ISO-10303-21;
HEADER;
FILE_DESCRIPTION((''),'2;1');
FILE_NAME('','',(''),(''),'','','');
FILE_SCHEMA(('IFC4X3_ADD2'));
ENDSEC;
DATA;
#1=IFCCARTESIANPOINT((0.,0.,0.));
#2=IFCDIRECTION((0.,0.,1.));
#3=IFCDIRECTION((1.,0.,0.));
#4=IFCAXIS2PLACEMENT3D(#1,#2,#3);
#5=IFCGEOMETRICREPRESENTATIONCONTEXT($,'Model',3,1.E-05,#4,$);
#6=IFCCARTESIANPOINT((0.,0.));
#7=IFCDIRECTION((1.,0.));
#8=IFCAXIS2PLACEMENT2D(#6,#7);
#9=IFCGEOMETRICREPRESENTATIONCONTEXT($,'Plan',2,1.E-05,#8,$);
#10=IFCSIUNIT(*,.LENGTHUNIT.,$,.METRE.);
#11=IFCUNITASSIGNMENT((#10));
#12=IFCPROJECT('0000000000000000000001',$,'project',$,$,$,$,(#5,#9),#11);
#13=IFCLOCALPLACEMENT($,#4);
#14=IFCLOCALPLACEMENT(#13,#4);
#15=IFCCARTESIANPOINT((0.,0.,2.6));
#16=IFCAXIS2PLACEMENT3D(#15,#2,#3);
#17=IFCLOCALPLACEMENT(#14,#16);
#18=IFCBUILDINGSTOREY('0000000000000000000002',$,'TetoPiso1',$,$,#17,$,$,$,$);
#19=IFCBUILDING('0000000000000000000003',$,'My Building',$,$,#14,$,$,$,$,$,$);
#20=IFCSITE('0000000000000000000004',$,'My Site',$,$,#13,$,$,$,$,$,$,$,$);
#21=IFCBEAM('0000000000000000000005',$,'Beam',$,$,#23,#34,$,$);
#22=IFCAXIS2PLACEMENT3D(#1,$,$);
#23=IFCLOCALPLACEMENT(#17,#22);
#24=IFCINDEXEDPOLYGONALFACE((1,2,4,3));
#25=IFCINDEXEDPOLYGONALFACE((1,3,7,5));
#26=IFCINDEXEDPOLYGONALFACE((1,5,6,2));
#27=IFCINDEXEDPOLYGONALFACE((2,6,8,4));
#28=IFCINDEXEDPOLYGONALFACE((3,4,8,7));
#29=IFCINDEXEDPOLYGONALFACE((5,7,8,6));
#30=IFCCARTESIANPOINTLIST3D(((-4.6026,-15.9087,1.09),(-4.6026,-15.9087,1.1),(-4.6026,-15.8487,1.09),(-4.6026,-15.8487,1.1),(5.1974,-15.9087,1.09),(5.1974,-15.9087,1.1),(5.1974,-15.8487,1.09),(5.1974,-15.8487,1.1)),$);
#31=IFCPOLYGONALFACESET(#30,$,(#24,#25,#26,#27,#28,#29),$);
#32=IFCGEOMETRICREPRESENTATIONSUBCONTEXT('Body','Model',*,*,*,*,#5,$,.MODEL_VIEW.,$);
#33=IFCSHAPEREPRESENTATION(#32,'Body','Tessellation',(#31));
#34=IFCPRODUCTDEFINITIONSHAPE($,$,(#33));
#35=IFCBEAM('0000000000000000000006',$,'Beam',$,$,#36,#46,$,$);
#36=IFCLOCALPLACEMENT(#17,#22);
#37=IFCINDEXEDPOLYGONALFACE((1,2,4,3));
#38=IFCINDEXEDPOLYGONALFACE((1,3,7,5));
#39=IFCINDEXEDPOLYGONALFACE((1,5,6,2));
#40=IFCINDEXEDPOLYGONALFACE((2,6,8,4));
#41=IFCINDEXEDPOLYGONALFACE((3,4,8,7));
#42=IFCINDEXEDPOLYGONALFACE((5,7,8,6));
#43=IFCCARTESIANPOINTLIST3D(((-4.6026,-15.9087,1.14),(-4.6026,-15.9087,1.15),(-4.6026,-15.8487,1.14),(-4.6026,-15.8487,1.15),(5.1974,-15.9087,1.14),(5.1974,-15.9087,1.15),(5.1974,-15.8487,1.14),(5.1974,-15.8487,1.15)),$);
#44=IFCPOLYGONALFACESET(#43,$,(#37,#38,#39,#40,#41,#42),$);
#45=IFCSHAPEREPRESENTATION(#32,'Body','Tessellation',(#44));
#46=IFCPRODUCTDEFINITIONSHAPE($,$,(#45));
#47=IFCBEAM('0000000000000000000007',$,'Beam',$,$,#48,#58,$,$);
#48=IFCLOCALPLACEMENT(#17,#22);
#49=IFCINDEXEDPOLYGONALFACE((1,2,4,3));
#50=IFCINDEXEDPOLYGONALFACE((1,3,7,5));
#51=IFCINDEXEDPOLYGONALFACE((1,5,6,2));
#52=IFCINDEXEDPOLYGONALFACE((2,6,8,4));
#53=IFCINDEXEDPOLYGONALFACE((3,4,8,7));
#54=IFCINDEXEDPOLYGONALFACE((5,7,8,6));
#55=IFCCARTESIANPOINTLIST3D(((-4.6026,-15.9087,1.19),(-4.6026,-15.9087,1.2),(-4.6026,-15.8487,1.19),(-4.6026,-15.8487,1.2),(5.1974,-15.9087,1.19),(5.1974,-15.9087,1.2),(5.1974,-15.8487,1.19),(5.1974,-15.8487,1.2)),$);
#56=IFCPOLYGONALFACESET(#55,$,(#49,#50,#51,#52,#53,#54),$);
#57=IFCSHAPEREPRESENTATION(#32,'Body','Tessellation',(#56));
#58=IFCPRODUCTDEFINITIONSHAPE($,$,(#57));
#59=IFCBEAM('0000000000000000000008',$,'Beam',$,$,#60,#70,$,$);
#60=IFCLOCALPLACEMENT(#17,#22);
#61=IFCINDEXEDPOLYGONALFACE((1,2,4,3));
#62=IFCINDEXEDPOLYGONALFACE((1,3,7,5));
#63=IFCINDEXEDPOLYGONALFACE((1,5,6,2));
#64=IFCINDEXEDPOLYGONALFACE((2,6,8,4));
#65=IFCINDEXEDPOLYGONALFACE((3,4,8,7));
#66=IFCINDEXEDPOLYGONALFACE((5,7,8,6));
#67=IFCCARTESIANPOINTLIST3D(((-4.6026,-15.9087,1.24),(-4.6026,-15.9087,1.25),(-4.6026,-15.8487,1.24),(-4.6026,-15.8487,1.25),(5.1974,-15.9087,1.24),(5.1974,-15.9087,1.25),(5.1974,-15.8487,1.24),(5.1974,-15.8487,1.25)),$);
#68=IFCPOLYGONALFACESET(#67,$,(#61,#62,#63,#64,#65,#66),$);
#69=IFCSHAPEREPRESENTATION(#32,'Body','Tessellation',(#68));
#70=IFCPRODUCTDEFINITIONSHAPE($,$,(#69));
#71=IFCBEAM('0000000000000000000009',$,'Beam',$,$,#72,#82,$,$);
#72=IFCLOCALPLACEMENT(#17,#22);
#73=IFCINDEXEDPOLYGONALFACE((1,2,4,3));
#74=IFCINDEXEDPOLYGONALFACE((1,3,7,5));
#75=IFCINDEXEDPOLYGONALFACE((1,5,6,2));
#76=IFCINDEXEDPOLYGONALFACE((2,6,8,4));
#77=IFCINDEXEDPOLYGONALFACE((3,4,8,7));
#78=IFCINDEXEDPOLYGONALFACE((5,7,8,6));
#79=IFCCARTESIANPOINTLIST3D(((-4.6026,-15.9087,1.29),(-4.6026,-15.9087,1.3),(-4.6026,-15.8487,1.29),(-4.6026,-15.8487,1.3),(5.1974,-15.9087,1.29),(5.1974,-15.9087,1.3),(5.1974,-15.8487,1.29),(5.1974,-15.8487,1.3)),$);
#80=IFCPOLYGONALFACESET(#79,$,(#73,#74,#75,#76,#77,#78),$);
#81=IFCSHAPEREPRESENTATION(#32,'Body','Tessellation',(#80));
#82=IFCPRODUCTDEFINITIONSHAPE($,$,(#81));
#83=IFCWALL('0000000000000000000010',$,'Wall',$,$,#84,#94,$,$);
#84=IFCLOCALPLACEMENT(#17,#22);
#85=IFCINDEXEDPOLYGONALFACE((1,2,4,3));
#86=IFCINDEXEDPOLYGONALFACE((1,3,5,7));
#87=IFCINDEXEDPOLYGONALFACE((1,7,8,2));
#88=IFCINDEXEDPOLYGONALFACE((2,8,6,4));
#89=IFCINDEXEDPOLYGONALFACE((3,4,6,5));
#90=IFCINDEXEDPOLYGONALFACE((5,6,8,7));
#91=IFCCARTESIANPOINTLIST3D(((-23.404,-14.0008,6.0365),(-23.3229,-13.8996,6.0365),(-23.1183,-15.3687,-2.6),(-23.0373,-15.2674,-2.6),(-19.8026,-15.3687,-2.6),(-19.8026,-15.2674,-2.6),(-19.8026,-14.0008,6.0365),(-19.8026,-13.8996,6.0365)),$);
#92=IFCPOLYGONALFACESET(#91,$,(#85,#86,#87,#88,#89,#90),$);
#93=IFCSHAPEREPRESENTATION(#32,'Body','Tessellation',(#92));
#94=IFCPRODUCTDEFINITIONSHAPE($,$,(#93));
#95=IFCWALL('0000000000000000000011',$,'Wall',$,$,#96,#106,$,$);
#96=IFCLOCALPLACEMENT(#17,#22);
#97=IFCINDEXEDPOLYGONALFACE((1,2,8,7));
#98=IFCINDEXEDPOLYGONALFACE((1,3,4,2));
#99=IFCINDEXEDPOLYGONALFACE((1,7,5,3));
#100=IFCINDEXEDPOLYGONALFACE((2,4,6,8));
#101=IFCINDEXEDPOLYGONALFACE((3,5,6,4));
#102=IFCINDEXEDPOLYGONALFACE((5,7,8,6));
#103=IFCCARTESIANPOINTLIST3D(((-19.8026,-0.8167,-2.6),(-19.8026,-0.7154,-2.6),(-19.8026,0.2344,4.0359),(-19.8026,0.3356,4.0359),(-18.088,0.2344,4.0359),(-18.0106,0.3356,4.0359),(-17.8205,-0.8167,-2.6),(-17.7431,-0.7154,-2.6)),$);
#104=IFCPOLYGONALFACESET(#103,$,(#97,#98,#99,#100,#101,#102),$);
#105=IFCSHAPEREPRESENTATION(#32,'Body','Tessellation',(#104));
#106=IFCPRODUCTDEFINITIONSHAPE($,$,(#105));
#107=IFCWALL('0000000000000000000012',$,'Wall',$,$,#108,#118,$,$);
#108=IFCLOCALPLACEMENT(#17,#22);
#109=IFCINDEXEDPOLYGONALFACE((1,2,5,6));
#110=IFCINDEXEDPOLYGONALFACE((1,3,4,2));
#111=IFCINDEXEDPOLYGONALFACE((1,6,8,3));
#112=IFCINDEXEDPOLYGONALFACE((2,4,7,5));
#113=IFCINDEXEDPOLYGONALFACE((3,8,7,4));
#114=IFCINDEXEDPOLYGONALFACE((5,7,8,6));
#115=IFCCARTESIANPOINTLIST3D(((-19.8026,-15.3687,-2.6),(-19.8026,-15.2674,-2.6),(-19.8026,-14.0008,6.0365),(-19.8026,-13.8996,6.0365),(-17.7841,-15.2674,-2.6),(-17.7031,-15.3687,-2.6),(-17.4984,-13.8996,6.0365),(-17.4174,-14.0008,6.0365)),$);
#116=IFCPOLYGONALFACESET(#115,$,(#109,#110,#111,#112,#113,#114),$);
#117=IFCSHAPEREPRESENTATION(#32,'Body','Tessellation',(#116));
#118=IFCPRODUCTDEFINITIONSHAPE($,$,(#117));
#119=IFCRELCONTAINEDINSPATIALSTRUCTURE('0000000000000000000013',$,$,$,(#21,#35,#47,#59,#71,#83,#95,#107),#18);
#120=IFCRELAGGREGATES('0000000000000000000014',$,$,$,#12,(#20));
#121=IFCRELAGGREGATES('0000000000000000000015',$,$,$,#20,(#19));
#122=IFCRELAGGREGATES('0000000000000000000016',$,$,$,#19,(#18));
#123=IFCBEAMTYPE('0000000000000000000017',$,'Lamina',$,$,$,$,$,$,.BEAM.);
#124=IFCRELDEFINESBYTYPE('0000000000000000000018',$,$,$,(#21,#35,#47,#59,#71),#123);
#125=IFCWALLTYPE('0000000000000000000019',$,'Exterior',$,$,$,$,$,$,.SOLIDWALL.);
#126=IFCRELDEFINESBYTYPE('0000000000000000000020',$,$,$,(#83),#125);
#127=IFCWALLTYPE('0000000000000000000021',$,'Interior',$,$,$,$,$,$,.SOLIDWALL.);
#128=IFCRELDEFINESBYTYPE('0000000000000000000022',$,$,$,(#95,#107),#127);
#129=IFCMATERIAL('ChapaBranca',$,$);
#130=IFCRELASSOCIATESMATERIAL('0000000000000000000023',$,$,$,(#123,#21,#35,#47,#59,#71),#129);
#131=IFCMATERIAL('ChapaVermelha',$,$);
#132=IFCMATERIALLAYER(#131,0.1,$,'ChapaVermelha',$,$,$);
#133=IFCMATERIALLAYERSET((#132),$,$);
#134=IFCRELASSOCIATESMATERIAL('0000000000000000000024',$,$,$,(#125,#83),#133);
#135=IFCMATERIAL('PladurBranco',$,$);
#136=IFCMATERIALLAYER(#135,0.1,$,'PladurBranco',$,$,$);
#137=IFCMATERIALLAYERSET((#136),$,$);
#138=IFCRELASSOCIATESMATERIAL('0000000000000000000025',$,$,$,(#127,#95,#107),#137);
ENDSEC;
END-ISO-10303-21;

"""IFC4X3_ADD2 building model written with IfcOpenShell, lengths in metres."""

from ifc_helpers import new_model, si_unit, frame, origin_with_axes, origin_2d, origin_2d_with_axis, place, context, subcontext, project, spatial, line, indexed_curve, rectangle, outline, extrude, boolean, material, layer, layer_set, layer_usage, material_profile, profile_set, profile_usage, type_object, element, save


model = new_model("IFC4X3_ADD2")

# Units and contexts
model_context = context("Model", 3, precision=1e-05, world=origin_with_axes())
plan_context = context("Plan", 2, precision=1e-05, world=origin_2d_with_axis())
body_context = subcontext(model_context, "Body", "Model", "MODEL_VIEW")
ifc_project = project(units=[si_unit("LENGTHUNIT", "METRE")], contexts=[model_context, plan_context])

# Site, building, storey
site_placement = place(None, origin_with_axes())
site = spatial("IfcSite", under=ifc_project, at=site_placement, Name="My Site")
building_placement = place(site_placement, origin_with_axes())
building = spatial("IfcBuilding", under=site, at=building_placement, Name="My Building")
storey_placement = place(building_placement, frame((0.0, 0.0, 2.6), z_axis=(0.0, 0.0, 1.0), x_axis=(1.0, 0.0, 0.0)))
storey = spatial("IfcBuildingStorey", under=building, at=storey_placement, Name="TetoPiso1")

# Beams
ifc_material_1 = material(Name="ChapaBranca")
ifc_material_profile_1 = material_profile(ifc_material_1, rectangle(XDim=0.06, YDim=0.01, at=origin_2d()))
ifc_profile_set_1 = profile_set([ifc_material_profile_1])
beam_type_1 = type_object("IfcBeamType", Name="Lamina", PredefinedType="BEAM", material=ifc_profile_set_1)
ifc_profile_usage_1 = profile_usage(ifc_profile_set_1, cardinal=5)
beam_1_placement = place(storey_placement, frame((-4.6026, -15.8787, 1.095), z_axis=(1.0, 0.0, 0.0), x_axis=(0.0, 1.0, 0.0)))
element("IfcBeam", 1, at=beam_1_placement, inside=storey, type_object=beam_type_1, material=ifc_profile_usage_1, Name="Beam", context=body_context, shape_type="SweptSolid", body=[
    extrude(rectangle(XDim=0.06, YDim=0.01, at=origin_2d()), origin_with_axes(), (0.0, 0.0, 1.0), 9.8),
])
ifc_profile_usage_2 = profile_usage(ifc_profile_set_1, cardinal=5)
beam_2_placement = place(storey_placement, frame((-4.6026, -15.8787, 1.145), z_axis=(1.0, 0.0, 0.0), x_axis=(0.0, 1.0, 0.0)))
element("IfcBeam", 2, at=beam_2_placement, inside=storey, type_object=beam_type_1, material=ifc_profile_usage_2, Name="Beam", context=body_context, shape_type="SweptSolid", body=[
    extrude(rectangle(XDim=0.06, YDim=0.01, at=origin_2d()), origin_with_axes(), (0.0, 0.0, 1.0), 9.8),
])
ifc_profile_usage_3 = profile_usage(ifc_profile_set_1, cardinal=5)
beam_3_placement = place(storey_placement, frame((-4.6026, -15.8787, 1.195), z_axis=(1.0, 0.0, 0.0), x_axis=(0.0, 1.0, 0.0)))
element("IfcBeam", 3, at=beam_3_placement, inside=storey, type_object=beam_type_1, material=ifc_profile_usage_3, Name="Beam", context=body_context, shape_type="SweptSolid", body=[
    extrude(rectangle(XDim=0.06, YDim=0.01, at=origin_2d()), origin_with_axes(), (0.0, 0.0, 1.0), 9.8),
])
ifc_profile_usage_4 = profile_usage(ifc_profile_set_1, cardinal=5)
beam_4_placement = place(storey_placement, frame((-4.6026, -15.8787, 1.245), z_axis=(1.0, 0.0, 0.0), x_axis=(0.0, 1.0, 0.0)))
element("IfcBeam", 4, at=beam_4_placement, inside=storey, type_object=beam_type_1, material=ifc_profile_usage_4, Name="Beam", context=body_context, shape_type="SweptSolid", body=[
    extrude(rectangle(XDim=0.06, YDim=0.01, at=origin_2d()), origin_with_axes(), (0.0, 0.0, 1.0), 9.8),
])
ifc_profile_usage_5 = profile_usage(ifc_profile_set_1, cardinal=5)
beam_5_placement = place(storey_placement, frame((-4.6026, -15.8787, 1.295), z_axis=(1.0, 0.0, 0.0), x_axis=(0.0, 1.0, 0.0)))
element("IfcBeam", 5, at=beam_5_placement, inside=storey, type_object=beam_type_1, material=ifc_profile_usage_5, Name="Beam", context=body_context, shape_type="SweptSolid", body=[
    extrude(rectangle(XDim=0.06, YDim=0.01, at=origin_2d()), origin_with_axes(), (0.0, 0.0, 1.0), 9.8),
])

# Walls
ifc_material_2 = material(Name="ChapaVermelha")
ifc_layer_1 = layer(ifc_material_2, 0.1, Name="ChapaVermelha")
ifc_layer_set_1 = layer_set([ifc_layer_1])
wall_type_1 = type_object("IfcWallType", Name="Exterior", PredefinedType="SOLIDWALL", material=ifc_layer_set_1)
ifc_layer_usage_1 = layer_usage(ifc_layer_set_1, "AXIS2", "POSITIVE", 0.0)
wall_1_placement = place(storey_placement, frame((-23.1183, -15.3687, -2.6), z_axis=(0.0, 0.0, 1.0), x_axis=(1.0, 0.0, 0.0)))
element("IfcWall", 6, at=wall_1_placement, inside=storey, type_object=wall_type_1, material=ifc_layer_usage_1, Name="Wall", context=body_context, shape_type="CSG", body=[
    boolean("DIFFERENCE", extrude(outline(indexed_curve([(-0.2857, 0.0), (-0.2047, 0.1012), (3.3157, 0.1012), (3.3157, 0.0)], segments=[line(1, 2, 3, 4, 1)])), origin_with_axes(), (0.0, 0.156434, 0.987688), 8.7442), extrude(outline(indexed_curve([(0.0, 0.0), (0.081, 0.1012), (-0.2857, 0.1012), (-0.2857, 0.0)], segments=[line(1, 2, 3, 4, 1)])), origin_with_axes(), (-0.031981, 0.15313, 0.966827), 8.7488)),
])
ifc_material_3 = material(Name="PladurBranco")
ifc_layer_2 = layer(ifc_material_3, 0.1, Name="PladurBranco")
ifc_layer_set_2 = layer_set([ifc_layer_2])
ifc_layer_usage_2 = layer_usage(ifc_layer_set_2, "AXIS2", "POSITIVE", 0.0)
wall_type_2 = type_object("IfcWallType", Name="Interior", PredefinedType="SOLIDWALL", material=ifc_layer_set_2)
wall_2_placement = place(storey_placement, frame((-19.8026, -0.8167, -2.6), z_axis=(0.0, 0.0, 1.0), x_axis=(1.0, 0.0, 0.0)))
element("IfcWall", 7, at=wall_2_placement, inside=storey, type_object=wall_type_2, material=ifc_layer_usage_2, Name="Wall", context=body_context, shape_type="CSG", body=[
    boolean("DIFFERENCE", extrude(outline(indexed_curve([(0.0, 0.0), (0.0, 0.1012), (2.0595, 0.1012), (1.9821, 0.0)], segments=[line(1, 2, 3, 4, 1)])), origin_with_axes(), (0.0, 0.156434, 0.987688), 6.7186), extrude(outline(indexed_curve([(1.9821, 0.0), (2.0595, 0.1012), (2.3271, 0.1012), (2.3271, 0.0)], segments=[line(1, 2, 3, 4, 1)])), origin_with_axes(), (-0.038586, 0.151601, 0.957171), 6.7239)),
])
ifc_layer_usage_3 = layer_usage(ifc_layer_set_2, "AXIS2", "POSITIVE", 0.0)
wall_3_placement = place(storey_placement, frame((-19.8026, -15.3687, -2.6), z_axis=(0.0, 0.0, 1.0), x_axis=(1.0, 0.0, 0.0)))
element("IfcWall", 8, at=wall_3_placement, inside=storey, type_object=wall_type_2, material=ifc_layer_usage_3, Name="Wall", context=body_context, shape_type="CSG", body=[
    boolean("DIFFERENCE", extrude(outline(indexed_curve([(0.0, 0.0), (0.0, 0.1012), (2.3042, 0.1012), (2.3852, 0.0)], segments=[line(1, 2, 3, 4, 1)])), origin_with_axes(), (0.0, 0.156434, 0.987688), 8.7442), extrude(outline(indexed_curve([(2.0995, 0.0), (2.0185, 0.1012), (2.3852, 0.1012), (2.3852, 0.0)], segments=[line(1, 2, 3, 4, 1)])), origin_with_axes(), (0.031981, 0.153131, 0.966828), 8.7488)),
])

save(model, "model.ifc")
